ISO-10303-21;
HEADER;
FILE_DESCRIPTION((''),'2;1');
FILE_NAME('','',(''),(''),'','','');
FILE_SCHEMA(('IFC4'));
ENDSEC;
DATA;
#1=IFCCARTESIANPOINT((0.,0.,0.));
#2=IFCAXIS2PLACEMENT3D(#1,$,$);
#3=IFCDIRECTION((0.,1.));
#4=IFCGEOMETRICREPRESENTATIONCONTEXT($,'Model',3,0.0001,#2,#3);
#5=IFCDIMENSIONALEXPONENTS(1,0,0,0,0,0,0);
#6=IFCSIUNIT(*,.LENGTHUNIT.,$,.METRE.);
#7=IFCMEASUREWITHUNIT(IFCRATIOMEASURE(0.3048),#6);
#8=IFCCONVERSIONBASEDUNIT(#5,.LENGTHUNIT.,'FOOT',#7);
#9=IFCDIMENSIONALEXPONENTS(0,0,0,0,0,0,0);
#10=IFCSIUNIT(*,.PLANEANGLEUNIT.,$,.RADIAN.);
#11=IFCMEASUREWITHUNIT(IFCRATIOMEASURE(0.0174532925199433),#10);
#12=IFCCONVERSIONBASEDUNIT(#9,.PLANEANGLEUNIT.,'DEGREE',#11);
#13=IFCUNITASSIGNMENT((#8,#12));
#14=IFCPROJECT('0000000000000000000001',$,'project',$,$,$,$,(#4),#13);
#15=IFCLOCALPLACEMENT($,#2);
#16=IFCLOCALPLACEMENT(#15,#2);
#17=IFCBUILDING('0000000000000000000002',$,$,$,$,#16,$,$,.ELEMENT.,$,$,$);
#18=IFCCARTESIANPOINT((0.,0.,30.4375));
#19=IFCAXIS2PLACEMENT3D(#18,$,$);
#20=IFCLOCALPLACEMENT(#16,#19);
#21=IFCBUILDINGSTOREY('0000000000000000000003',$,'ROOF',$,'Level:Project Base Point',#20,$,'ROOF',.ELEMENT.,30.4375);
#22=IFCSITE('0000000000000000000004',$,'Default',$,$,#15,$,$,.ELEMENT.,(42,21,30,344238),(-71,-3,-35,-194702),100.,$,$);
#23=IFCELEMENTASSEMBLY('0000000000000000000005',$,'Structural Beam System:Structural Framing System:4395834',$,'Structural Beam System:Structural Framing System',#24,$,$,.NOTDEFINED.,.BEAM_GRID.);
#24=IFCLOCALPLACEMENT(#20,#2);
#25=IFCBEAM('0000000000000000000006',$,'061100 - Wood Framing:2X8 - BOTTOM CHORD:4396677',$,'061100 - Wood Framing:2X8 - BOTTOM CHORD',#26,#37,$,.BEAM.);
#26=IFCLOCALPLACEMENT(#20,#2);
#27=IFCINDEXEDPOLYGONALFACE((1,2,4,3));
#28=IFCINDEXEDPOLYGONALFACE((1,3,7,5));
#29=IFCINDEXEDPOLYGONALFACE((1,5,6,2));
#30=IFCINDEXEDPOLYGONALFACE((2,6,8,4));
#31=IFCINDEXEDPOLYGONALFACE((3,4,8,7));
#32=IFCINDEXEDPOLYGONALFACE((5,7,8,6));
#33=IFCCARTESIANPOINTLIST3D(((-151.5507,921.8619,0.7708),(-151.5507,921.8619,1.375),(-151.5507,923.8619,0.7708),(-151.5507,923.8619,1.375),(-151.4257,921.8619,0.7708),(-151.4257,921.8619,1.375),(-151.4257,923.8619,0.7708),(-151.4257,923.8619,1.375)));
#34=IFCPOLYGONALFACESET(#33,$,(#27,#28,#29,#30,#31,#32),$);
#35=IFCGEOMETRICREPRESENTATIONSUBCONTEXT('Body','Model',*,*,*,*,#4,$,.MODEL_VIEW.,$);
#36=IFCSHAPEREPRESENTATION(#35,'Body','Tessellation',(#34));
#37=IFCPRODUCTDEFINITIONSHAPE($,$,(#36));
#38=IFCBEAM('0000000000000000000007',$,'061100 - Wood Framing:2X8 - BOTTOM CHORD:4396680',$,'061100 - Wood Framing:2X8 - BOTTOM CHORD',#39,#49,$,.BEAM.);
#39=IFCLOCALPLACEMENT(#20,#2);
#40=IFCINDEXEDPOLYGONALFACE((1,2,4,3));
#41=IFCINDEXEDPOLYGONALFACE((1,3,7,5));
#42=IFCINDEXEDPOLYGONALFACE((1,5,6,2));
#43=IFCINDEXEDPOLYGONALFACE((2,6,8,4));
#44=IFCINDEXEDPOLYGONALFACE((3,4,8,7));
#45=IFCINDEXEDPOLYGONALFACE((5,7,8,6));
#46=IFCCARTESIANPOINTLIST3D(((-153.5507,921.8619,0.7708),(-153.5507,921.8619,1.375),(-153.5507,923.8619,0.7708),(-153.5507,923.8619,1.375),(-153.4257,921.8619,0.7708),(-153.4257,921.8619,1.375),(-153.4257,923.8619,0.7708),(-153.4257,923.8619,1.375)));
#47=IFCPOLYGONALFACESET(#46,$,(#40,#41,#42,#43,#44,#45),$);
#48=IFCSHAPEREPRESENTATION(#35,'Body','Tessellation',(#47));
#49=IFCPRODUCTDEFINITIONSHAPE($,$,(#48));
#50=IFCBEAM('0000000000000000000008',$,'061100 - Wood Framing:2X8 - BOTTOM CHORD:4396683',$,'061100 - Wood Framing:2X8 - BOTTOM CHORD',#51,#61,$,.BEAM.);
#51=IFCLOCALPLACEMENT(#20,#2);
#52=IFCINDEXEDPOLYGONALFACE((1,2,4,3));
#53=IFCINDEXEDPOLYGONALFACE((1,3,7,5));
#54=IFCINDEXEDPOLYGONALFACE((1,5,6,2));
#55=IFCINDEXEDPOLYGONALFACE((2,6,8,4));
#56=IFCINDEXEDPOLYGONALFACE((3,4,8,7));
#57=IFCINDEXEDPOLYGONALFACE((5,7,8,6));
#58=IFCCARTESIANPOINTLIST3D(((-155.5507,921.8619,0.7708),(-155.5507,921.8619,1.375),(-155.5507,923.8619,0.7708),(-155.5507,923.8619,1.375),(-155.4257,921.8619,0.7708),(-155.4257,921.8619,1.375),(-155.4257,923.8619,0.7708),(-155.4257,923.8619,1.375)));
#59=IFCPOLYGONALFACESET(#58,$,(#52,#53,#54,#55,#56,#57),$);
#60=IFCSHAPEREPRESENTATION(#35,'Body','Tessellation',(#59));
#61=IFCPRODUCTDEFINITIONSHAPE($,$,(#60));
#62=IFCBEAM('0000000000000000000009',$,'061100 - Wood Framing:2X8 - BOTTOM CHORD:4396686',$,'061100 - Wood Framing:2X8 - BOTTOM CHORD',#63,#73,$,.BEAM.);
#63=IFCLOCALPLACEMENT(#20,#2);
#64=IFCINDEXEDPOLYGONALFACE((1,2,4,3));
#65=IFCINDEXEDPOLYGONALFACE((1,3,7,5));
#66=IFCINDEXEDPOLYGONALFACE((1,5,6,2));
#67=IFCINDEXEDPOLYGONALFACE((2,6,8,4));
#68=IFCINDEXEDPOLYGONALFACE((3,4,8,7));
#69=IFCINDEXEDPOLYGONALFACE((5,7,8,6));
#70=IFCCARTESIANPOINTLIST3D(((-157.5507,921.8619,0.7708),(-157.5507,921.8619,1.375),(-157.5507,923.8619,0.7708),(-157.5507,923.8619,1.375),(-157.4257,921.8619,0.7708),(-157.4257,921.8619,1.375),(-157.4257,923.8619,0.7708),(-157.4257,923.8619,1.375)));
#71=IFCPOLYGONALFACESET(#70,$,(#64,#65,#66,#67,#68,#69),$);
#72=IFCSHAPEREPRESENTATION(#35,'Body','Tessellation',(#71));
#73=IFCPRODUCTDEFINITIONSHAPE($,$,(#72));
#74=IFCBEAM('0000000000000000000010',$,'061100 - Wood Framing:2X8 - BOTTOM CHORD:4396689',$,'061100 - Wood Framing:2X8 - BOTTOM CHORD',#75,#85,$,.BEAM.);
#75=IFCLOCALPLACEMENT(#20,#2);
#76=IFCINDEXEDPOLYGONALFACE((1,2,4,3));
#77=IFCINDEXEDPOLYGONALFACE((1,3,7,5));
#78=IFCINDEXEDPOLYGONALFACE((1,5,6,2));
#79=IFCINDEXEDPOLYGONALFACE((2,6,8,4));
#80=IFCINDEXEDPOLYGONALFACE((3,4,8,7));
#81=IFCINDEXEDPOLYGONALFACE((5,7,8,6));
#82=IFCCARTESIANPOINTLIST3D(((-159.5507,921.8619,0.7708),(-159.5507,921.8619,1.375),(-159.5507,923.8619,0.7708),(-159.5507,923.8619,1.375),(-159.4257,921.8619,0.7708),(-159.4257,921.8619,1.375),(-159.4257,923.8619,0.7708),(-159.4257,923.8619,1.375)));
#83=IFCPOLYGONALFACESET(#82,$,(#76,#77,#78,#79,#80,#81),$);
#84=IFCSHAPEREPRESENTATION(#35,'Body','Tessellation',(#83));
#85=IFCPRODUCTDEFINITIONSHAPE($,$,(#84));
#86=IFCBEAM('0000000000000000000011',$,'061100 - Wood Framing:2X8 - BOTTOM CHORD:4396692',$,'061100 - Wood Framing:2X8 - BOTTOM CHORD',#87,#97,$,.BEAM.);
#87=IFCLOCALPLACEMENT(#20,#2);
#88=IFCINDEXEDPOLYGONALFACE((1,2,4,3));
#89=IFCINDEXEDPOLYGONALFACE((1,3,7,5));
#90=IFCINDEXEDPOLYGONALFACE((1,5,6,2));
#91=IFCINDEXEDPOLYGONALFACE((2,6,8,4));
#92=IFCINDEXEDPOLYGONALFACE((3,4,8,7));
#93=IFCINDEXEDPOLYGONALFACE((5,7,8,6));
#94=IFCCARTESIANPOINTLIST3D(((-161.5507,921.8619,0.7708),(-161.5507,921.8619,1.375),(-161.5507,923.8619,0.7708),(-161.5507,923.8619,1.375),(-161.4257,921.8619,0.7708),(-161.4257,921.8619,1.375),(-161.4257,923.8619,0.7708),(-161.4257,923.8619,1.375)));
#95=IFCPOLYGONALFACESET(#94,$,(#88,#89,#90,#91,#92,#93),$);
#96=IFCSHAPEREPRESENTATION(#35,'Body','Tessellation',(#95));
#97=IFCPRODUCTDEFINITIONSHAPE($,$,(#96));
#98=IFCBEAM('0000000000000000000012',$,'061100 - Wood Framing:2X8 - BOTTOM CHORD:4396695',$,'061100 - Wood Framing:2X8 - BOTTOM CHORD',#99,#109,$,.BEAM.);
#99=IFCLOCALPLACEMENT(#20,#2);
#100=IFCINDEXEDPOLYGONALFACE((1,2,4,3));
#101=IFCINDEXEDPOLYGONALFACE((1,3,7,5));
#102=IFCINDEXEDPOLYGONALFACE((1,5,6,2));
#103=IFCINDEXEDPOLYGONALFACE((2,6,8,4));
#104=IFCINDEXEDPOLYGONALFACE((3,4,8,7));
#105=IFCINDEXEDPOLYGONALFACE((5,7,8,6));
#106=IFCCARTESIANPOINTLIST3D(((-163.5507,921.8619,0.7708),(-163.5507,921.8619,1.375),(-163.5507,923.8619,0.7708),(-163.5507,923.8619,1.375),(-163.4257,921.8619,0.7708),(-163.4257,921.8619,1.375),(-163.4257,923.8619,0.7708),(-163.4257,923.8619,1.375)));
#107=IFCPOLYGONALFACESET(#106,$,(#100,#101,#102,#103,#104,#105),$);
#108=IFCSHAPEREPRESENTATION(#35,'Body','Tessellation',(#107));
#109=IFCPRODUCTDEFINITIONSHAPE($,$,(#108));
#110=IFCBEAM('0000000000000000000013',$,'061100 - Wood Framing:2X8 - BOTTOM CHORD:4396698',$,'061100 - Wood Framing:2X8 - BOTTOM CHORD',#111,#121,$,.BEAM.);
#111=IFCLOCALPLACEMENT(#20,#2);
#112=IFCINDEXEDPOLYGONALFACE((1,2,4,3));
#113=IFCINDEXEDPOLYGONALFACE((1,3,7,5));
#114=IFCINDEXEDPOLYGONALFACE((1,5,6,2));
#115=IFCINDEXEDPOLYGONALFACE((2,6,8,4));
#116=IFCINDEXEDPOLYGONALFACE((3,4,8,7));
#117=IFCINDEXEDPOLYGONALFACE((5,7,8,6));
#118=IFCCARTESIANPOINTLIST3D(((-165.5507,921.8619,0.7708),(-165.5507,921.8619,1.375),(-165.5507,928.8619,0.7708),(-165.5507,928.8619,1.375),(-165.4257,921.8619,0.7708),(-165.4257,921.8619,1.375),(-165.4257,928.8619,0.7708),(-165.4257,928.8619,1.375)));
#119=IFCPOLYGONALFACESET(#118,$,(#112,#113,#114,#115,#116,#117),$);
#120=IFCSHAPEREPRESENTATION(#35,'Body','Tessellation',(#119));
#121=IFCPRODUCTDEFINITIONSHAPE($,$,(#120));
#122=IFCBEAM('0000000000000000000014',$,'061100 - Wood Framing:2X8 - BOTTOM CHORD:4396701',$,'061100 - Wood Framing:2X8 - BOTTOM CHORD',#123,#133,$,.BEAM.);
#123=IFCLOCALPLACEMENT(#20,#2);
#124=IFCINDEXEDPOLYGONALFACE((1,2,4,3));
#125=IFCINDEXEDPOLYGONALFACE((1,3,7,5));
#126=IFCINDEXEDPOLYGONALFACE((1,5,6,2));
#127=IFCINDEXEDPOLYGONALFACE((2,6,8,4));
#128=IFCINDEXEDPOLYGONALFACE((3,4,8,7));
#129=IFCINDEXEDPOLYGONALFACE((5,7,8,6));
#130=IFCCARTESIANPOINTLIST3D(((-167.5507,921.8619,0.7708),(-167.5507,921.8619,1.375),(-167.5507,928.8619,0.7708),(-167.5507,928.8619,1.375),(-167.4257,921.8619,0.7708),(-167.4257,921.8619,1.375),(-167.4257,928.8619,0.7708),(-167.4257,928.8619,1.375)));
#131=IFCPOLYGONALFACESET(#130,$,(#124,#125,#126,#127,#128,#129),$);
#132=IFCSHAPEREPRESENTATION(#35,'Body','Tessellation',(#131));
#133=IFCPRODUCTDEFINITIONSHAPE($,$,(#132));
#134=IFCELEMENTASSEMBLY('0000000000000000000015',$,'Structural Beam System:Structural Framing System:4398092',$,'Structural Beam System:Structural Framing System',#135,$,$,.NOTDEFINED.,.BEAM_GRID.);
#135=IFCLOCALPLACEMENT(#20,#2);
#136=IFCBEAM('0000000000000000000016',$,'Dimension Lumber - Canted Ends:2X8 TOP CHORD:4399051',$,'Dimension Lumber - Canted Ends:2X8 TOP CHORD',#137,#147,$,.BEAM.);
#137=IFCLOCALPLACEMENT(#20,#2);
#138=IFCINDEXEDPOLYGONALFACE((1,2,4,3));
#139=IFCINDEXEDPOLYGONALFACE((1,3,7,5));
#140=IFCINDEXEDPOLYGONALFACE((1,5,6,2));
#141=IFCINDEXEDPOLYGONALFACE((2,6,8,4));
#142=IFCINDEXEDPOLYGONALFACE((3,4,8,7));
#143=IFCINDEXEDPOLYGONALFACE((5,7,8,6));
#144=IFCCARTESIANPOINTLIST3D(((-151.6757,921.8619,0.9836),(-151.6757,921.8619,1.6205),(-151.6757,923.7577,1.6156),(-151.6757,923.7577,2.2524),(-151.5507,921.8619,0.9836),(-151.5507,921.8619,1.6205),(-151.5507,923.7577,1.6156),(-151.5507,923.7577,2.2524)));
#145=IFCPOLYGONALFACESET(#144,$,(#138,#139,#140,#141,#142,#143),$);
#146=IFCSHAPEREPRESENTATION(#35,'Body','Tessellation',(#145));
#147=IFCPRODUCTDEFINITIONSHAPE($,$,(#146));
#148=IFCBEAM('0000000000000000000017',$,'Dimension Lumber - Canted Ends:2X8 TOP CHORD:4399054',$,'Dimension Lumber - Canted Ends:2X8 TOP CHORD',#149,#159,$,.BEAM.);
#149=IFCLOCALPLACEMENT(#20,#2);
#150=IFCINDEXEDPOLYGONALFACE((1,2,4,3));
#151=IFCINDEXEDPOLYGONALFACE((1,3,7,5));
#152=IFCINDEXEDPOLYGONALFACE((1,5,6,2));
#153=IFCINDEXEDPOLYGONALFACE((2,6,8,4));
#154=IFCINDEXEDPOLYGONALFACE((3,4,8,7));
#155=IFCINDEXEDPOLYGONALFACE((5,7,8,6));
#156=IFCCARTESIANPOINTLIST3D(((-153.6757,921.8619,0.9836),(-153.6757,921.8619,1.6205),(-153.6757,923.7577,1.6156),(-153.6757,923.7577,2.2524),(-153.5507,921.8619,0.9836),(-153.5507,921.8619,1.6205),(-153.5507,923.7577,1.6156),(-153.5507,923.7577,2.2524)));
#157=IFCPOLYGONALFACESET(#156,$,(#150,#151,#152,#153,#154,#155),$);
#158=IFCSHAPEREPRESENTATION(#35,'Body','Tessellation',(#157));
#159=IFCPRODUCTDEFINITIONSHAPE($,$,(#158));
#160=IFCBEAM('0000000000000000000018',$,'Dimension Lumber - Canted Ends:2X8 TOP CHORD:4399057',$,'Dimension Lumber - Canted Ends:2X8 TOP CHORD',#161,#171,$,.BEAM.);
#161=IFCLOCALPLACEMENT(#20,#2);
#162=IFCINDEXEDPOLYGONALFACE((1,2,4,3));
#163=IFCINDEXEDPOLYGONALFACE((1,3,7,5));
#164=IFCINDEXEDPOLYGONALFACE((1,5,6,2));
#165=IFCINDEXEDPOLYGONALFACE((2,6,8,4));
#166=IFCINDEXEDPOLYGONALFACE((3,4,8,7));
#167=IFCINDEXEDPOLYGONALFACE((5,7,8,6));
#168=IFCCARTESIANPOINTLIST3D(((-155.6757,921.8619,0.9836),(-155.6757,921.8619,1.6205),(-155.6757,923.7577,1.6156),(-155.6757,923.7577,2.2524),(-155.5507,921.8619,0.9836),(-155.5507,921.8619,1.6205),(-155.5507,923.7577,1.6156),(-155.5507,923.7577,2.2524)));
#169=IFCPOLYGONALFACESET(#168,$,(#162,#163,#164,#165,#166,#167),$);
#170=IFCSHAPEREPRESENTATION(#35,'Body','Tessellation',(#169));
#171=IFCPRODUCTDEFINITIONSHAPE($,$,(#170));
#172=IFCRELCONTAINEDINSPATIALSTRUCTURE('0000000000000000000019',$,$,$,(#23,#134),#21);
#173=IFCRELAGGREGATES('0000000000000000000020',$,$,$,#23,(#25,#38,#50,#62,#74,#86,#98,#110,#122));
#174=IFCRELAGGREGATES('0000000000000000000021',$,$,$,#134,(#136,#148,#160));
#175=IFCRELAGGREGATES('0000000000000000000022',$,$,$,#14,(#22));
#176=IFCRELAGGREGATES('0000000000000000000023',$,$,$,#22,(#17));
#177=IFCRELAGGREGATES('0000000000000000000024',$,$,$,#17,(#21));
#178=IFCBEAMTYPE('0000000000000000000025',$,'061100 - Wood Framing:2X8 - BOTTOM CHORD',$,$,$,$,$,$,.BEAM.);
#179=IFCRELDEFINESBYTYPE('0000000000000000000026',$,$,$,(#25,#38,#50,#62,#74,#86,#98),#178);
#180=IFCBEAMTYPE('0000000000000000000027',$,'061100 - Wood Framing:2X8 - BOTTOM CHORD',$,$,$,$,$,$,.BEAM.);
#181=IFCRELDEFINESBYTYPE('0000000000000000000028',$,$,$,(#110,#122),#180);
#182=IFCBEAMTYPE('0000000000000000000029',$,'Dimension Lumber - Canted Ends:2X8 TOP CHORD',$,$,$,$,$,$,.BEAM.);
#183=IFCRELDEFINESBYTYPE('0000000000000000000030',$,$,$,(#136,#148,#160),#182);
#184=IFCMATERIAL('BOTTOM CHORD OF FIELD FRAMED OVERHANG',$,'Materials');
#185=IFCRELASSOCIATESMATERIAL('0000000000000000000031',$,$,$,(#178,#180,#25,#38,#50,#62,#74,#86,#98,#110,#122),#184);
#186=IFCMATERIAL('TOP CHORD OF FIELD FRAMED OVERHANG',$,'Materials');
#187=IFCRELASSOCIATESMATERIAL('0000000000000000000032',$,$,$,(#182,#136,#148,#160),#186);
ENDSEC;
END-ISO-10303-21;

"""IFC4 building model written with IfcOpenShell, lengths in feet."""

from ifc_helpers import new_model, entity, si_unit, converted_unit, direction, frame, origin, origin_2d_with_axis, place, context, subcontext, project, spatial, rectangle, extrude, clip, halfspace, source, transform, mapped, material, material_profile, profile_set, profile_usage, type_object, type_shapes, element, aggregate, save


model = new_model("IFC4")

# Units and contexts
model_context = context("Model", 3, precision=0.0001, world=origin(), true_north=direction((0.0, 1.0)))
body_context = subcontext(model_context, "Body", "Model", "MODEL_VIEW")
ifc_project = project(units=[converted_unit("LENGTHUNIT", "FOOT", entity("IfcRatioMeasure", 0.3048), si_unit("LENGTHUNIT", "METRE"), dimensions=[1, 0, 0, 0, 0, 0, 0]), converted_unit("PLANEANGLEUNIT", "DEGREE", entity("IfcRatioMeasure", 0.0174532925199433), si_unit("PLANEANGLEUNIT", "RADIAN"), dimensions=[0, 0, 0, 0, 0, 0, 0])], contexts=[model_context])

# Site, building, storey
site_placement = place(None, origin())
site = spatial("IfcSite", under=ifc_project, at=site_placement, Name="Default", CompositionType="ELEMENT", RefLatitude=(42, 21, 30, 344238), RefLongitude=(-71, -3, -35, -194702), RefElevation=100.0)
building_placement = place(site_placement, origin())
building = spatial("IfcBuilding", under=site, at=building_placement, CompositionType="ELEMENT")
storey_placement = place(building_placement, frame((0.0, 0.0, 30.4375)))
storey = spatial("IfcBuildingStorey", under=building, at=storey_placement, Name="ROOF", ObjectType="Level:Project Base Point", LongName="ROOF", CompositionType="ELEMENT", Elevation=30.4375)

# Element assemblies, beams
assembly_1_placement = place(storey_placement, origin())
assembly_1 = element("IfcElementAssembly", 1, at=assembly_1_placement, inside=storey, Name="Structural Beam System:Structural Framing System:4395834", ObjectType="Structural Beam System:Structural Framing System", AssemblyPlace="NOTDEFINED", PredefinedType="BEAM_GRID")
ifc_material_1 = material(Name="BOTTOM CHORD OF FIELD FRAMED OVERHANG", Category="Materials")
ifc_material_profile_1 = material_profile(ifc_material_1, rectangle(XDim=0.6042, YDim=0.125, at=origin_2d_with_axis()), Name="2X8 - BOTTOM CHORD")
ifc_profile_set_1 = profile_set([ifc_material_profile_1], Name="2X8 - BOTTOM CHORD")
ifc_profile_usage_1 = profile_usage(ifc_profile_set_1, cardinal=8)
beam_type_1 = type_object("IfcBeamType", Name="061100 - Wood Framing:2X8 - BOTTOM CHORD", PredefinedType="BEAM", material=ifc_profile_set_1)
shared_shape_1 = source(origin(), body_context, "Body", "SweptSolid", [
    extrude(rectangle(XDim=0.6042, YDim=0.125, at=origin_2d_with_axis()), frame((-1.0, 0.0, 0.0), z_axis=(1.0, 0.0, 0.0), x_axis=(0.0, 0.0, -1.0)), (0.0, 0.0, 1.0), 2.0),
])
type_shapes(beam_type_1, [shared_shape_1])
beam_1_placement = place(assembly_1_placement, frame((-151.4882, 922.8619, 1.0729), z_axis=(0.0, 0.0, 1.0), x_axis=(0.0, -1.0, 0.0)))
beam_1 = element("IfcBeam", 2, at=beam_1_placement, type_object=beam_type_1, material=ifc_profile_usage_1, Name="061100 - Wood Framing:2X8 - BOTTOM CHORD:4396677", ObjectType="061100 - Wood Framing:2X8 - BOTTOM CHORD", PredefinedType="BEAM", context=body_context, shape_type="MappedRepresentation", body=[
    mapped(shared_shape_1, transform((0.0, 0.0, 0.0), scale=1.0)),
])
ifc_profile_usage_2 = profile_usage(ifc_profile_set_1, cardinal=8)
beam_2_placement = place(assembly_1_placement, frame((-153.4882, 922.8619, 1.0729), z_axis=(0.0, 0.0, 1.0), x_axis=(0.0, -1.0, 0.0)))
beam_2 = element("IfcBeam", 3, at=beam_2_placement, type_object=beam_type_1, material=ifc_profile_usage_2, Name="061100 - Wood Framing:2X8 - BOTTOM CHORD:4396680", ObjectType="061100 - Wood Framing:2X8 - BOTTOM CHORD", PredefinedType="BEAM", context=body_context, shape_type="MappedRepresentation", body=[
    mapped(shared_shape_1, transform((0.0, 0.0, 0.0), scale=1.0)),
])
ifc_profile_usage_3 = profile_usage(ifc_profile_set_1, cardinal=8)
beam_3_placement = place(assembly_1_placement, frame((-155.4882, 922.8619, 1.0729), z_axis=(0.0, 0.0, 1.0), x_axis=(0.0, -1.0, 0.0)))
beam_3 = element("IfcBeam", 4, at=beam_3_placement, type_object=beam_type_1, material=ifc_profile_usage_3, Name="061100 - Wood Framing:2X8 - BOTTOM CHORD:4396683", ObjectType="061100 - Wood Framing:2X8 - BOTTOM CHORD", PredefinedType="BEAM", context=body_context, shape_type="MappedRepresentation", body=[
    mapped(shared_shape_1, transform((0.0, 0.0, 0.0), scale=1.0)),
])
ifc_profile_usage_4 = profile_usage(ifc_profile_set_1, cardinal=8)
beam_4_placement = place(assembly_1_placement, frame((-157.4882, 922.8619, 1.0729), z_axis=(0.0, 0.0, 1.0), x_axis=(0.0, -1.0, 0.0)))
beam_4 = element("IfcBeam", 5, at=beam_4_placement, type_object=beam_type_1, material=ifc_profile_usage_4, Name="061100 - Wood Framing:2X8 - BOTTOM CHORD:4396686", ObjectType="061100 - Wood Framing:2X8 - BOTTOM CHORD", PredefinedType="BEAM", context=body_context, shape_type="MappedRepresentation", body=[
    mapped(shared_shape_1, transform((0.0, 0.0, 0.0), scale=1.0)),
])
ifc_profile_usage_5 = profile_usage(ifc_profile_set_1, cardinal=8)
beam_5_placement = place(assembly_1_placement, frame((-159.4882, 922.8619, 1.0729), z_axis=(0.0, 0.0, 1.0), x_axis=(0.0, -1.0, 0.0)))
beam_5 = element("IfcBeam", 6, at=beam_5_placement, type_object=beam_type_1, material=ifc_profile_usage_5, Name="061100 - Wood Framing:2X8 - BOTTOM CHORD:4396689", ObjectType="061100 - Wood Framing:2X8 - BOTTOM CHORD", PredefinedType="BEAM", context=body_context, shape_type="MappedRepresentation", body=[
    mapped(shared_shape_1, transform((0.0, 0.0, 0.0), scale=1.0)),
])
ifc_profile_usage_6 = profile_usage(ifc_profile_set_1, cardinal=8)
beam_6_placement = place(assembly_1_placement, frame((-161.4882, 922.8619, 1.0729), z_axis=(0.0, 0.0, 1.0), x_axis=(0.0, -1.0, 0.0)))
beam_6 = element("IfcBeam", 7, at=beam_6_placement, type_object=beam_type_1, material=ifc_profile_usage_6, Name="061100 - Wood Framing:2X8 - BOTTOM CHORD:4396692", ObjectType="061100 - Wood Framing:2X8 - BOTTOM CHORD", PredefinedType="BEAM", context=body_context, shape_type="MappedRepresentation", body=[
    mapped(shared_shape_1, transform((0.0, 0.0, 0.0), scale=1.0)),
])
ifc_profile_usage_7 = profile_usage(ifc_profile_set_1, cardinal=8)
beam_7_placement = place(assembly_1_placement, frame((-163.4882, 922.8619, 1.0729), z_axis=(0.0, 0.0, 1.0), x_axis=(0.0, -1.0, 0.0)))
beam_7 = element("IfcBeam", 8, at=beam_7_placement, type_object=beam_type_1, material=ifc_profile_usage_7, Name="061100 - Wood Framing:2X8 - BOTTOM CHORD:4396695", ObjectType="061100 - Wood Framing:2X8 - BOTTOM CHORD", PredefinedType="BEAM", context=body_context, shape_type="MappedRepresentation", body=[
    mapped(shared_shape_1, transform((0.0, 0.0, 0.0), scale=1.0)),
])
ifc_profile_usage_8 = profile_usage(ifc_profile_set_1, cardinal=8)
beam_type_2 = type_object("IfcBeamType", Name="061100 - Wood Framing:2X8 - BOTTOM CHORD", PredefinedType="BEAM", material=ifc_profile_set_1)
shared_shape_2 = source(origin(), body_context, "Body", "SweptSolid", [
    extrude(rectangle(XDim=0.6042, YDim=0.125, at=origin_2d_with_axis()), frame((-3.5, 0.0, 0.0), z_axis=(1.0, 0.0, 0.0), x_axis=(0.0, 0.0, -1.0)), (0.0, 0.0, 1.0), 7.0),
])
type_shapes(beam_type_2, [shared_shape_2])
beam_8_placement = place(assembly_1_placement, frame((-165.4882, 925.3619, 1.0729), z_axis=(0.0, 0.0, 1.0), x_axis=(0.0, -1.0, 0.0)))
beam_8 = element("IfcBeam", 9, at=beam_8_placement, type_object=beam_type_2, material=ifc_profile_usage_8, Name="061100 - Wood Framing:2X8 - BOTTOM CHORD:4396698", ObjectType="061100 - Wood Framing:2X8 - BOTTOM CHORD", PredefinedType="BEAM", context=body_context, shape_type="MappedRepresentation", body=[
    mapped(shared_shape_2, transform((0.0, 0.0, 0.0), scale=1.0)),
])
ifc_profile_usage_9 = profile_usage(ifc_profile_set_1, cardinal=8)
beam_9_placement = place(assembly_1_placement, frame((-167.4882, 925.3619, 1.0729), z_axis=(0.0, 0.0, 1.0), x_axis=(0.0, -1.0, 0.0)))
beam_9 = element("IfcBeam", 10, at=beam_9_placement, type_object=beam_type_2, material=ifc_profile_usage_9, Name="061100 - Wood Framing:2X8 - BOTTOM CHORD:4396701", ObjectType="061100 - Wood Framing:2X8 - BOTTOM CHORD", PredefinedType="BEAM", context=body_context, shape_type="MappedRepresentation", body=[
    mapped(shared_shape_2, transform((0.0, 0.0, 0.0), scale=1.0)),
])
aggregate(assembly_1, [beam_1, beam_2, beam_3, beam_4, beam_5, beam_6, beam_7, beam_8, beam_9])
assembly_2_placement = place(storey_placement, origin())
assembly_2 = element("IfcElementAssembly", 11, at=assembly_2_placement, inside=storey, Name="Structural Beam System:Structural Framing System:4398092", ObjectType="Structural Beam System:Structural Framing System", AssemblyPlace="NOTDEFINED", PredefinedType="BEAM_GRID")
ifc_material_2 = material(Name="TOP CHORD OF FIELD FRAMED OVERHANG", Category="Materials")
ifc_material_profile_2 = material_profile(ifc_material_2, rectangle(XDim=0.6042, YDim=0.125, at=origin_2d_with_axis()), Name="2X8 TOP CHORD")
ifc_profile_set_2 = profile_set([ifc_material_profile_2], Name="2X8 TOP CHORD")
ifc_profile_usage_10 = profile_usage(ifc_profile_set_2, cardinal=8)
beam_type_3 = type_object("IfcBeamType", Name="Dimension Lumber - Canted Ends:2X8 TOP CHORD", PredefinedType="BEAM", material=ifc_profile_set_2)
shared_shape_3 = source(origin(), body_context, "Body", "Clipping", [
    clip(clip(extrude(rectangle(XDim=0.6042, YDim=0.125, at=origin_2d_with_axis()), frame((-0.9992, 0.0, 0.0), z_axis=(1.0, 0.0, 0.0), x_axis=(0.0, 0.0, -1.0)), (0.0, 0.0, 1.0), 2.1997), halfspace(frame((0.9992, -0.0625, -0.3021), z_axis=(0.948711, 0.0, -0.316146), x_axis=(0.0, 1.0, 0.0)), False)), halfspace(frame((-0.7979, -0.0625, 0.3021), z_axis=(-0.948711, 0.0, 0.316146), x_axis=(0.0, 1.0, 0.0)), False)),
])
type_shapes(beam_type_3, [shared_shape_3])
beam_10_placement = place(assembly_2_placement, frame((-151.6132, 922.7143, 1.5862), z_axis=(0.0, -0.316228, 0.948683), x_axis=(0.0, 0.948683, 0.316228)))
beam_10 = element("IfcBeam", 12, at=beam_10_placement, type_object=beam_type_3, material=ifc_profile_usage_10, Name="Dimension Lumber - Canted Ends:2X8 TOP CHORD:4399051", ObjectType="Dimension Lumber - Canted Ends:2X8 TOP CHORD", PredefinedType="BEAM", context=body_context, shape_type="MappedRepresentation", body=[
    mapped(shared_shape_3, transform((0.0, 0.0, 0.0), scale=1.0)),
])
ifc_profile_usage_11 = profile_usage(ifc_profile_set_2, cardinal=8)
beam_11_placement = place(assembly_2_placement, frame((-153.6132, 922.7143, 1.5862), z_axis=(0.0, -0.316228, 0.948683), x_axis=(0.0, 0.948683, 0.316228)))
beam_11 = element("IfcBeam", 13, at=beam_11_placement, type_object=beam_type_3, material=ifc_profile_usage_11, Name="Dimension Lumber - Canted Ends:2X8 TOP CHORD:4399054", ObjectType="Dimension Lumber - Canted Ends:2X8 TOP CHORD", PredefinedType="BEAM", context=body_context, shape_type="MappedRepresentation", body=[
    mapped(shared_shape_3, transform((0.0, 0.0, 0.0), scale=1.0)),
])
ifc_profile_usage_12 = profile_usage(ifc_profile_set_2, cardinal=8)
beam_12_placement = place(assembly_2_placement, frame((-155.6132, 922.7143, 1.5862), z_axis=(0.0, -0.316228, 0.948683), x_axis=(0.0, 0.948683, 0.316228)))
beam_12 = element("IfcBeam", 14, at=beam_12_placement, type_object=beam_type_3, material=ifc_profile_usage_12, Name="Dimension Lumber - Canted Ends:2X8 TOP CHORD:4399057", ObjectType="Dimension Lumber - Canted Ends:2X8 TOP CHORD", PredefinedType="BEAM", context=body_context, shape_type="MappedRepresentation", body=[
    mapped(shared_shape_3, transform((0.0, 0.0, 0.0), scale=1.0)),
])
aggregate(assembly_2, [beam_10, beam_11, beam_12])

save(model, "model.ifc")
